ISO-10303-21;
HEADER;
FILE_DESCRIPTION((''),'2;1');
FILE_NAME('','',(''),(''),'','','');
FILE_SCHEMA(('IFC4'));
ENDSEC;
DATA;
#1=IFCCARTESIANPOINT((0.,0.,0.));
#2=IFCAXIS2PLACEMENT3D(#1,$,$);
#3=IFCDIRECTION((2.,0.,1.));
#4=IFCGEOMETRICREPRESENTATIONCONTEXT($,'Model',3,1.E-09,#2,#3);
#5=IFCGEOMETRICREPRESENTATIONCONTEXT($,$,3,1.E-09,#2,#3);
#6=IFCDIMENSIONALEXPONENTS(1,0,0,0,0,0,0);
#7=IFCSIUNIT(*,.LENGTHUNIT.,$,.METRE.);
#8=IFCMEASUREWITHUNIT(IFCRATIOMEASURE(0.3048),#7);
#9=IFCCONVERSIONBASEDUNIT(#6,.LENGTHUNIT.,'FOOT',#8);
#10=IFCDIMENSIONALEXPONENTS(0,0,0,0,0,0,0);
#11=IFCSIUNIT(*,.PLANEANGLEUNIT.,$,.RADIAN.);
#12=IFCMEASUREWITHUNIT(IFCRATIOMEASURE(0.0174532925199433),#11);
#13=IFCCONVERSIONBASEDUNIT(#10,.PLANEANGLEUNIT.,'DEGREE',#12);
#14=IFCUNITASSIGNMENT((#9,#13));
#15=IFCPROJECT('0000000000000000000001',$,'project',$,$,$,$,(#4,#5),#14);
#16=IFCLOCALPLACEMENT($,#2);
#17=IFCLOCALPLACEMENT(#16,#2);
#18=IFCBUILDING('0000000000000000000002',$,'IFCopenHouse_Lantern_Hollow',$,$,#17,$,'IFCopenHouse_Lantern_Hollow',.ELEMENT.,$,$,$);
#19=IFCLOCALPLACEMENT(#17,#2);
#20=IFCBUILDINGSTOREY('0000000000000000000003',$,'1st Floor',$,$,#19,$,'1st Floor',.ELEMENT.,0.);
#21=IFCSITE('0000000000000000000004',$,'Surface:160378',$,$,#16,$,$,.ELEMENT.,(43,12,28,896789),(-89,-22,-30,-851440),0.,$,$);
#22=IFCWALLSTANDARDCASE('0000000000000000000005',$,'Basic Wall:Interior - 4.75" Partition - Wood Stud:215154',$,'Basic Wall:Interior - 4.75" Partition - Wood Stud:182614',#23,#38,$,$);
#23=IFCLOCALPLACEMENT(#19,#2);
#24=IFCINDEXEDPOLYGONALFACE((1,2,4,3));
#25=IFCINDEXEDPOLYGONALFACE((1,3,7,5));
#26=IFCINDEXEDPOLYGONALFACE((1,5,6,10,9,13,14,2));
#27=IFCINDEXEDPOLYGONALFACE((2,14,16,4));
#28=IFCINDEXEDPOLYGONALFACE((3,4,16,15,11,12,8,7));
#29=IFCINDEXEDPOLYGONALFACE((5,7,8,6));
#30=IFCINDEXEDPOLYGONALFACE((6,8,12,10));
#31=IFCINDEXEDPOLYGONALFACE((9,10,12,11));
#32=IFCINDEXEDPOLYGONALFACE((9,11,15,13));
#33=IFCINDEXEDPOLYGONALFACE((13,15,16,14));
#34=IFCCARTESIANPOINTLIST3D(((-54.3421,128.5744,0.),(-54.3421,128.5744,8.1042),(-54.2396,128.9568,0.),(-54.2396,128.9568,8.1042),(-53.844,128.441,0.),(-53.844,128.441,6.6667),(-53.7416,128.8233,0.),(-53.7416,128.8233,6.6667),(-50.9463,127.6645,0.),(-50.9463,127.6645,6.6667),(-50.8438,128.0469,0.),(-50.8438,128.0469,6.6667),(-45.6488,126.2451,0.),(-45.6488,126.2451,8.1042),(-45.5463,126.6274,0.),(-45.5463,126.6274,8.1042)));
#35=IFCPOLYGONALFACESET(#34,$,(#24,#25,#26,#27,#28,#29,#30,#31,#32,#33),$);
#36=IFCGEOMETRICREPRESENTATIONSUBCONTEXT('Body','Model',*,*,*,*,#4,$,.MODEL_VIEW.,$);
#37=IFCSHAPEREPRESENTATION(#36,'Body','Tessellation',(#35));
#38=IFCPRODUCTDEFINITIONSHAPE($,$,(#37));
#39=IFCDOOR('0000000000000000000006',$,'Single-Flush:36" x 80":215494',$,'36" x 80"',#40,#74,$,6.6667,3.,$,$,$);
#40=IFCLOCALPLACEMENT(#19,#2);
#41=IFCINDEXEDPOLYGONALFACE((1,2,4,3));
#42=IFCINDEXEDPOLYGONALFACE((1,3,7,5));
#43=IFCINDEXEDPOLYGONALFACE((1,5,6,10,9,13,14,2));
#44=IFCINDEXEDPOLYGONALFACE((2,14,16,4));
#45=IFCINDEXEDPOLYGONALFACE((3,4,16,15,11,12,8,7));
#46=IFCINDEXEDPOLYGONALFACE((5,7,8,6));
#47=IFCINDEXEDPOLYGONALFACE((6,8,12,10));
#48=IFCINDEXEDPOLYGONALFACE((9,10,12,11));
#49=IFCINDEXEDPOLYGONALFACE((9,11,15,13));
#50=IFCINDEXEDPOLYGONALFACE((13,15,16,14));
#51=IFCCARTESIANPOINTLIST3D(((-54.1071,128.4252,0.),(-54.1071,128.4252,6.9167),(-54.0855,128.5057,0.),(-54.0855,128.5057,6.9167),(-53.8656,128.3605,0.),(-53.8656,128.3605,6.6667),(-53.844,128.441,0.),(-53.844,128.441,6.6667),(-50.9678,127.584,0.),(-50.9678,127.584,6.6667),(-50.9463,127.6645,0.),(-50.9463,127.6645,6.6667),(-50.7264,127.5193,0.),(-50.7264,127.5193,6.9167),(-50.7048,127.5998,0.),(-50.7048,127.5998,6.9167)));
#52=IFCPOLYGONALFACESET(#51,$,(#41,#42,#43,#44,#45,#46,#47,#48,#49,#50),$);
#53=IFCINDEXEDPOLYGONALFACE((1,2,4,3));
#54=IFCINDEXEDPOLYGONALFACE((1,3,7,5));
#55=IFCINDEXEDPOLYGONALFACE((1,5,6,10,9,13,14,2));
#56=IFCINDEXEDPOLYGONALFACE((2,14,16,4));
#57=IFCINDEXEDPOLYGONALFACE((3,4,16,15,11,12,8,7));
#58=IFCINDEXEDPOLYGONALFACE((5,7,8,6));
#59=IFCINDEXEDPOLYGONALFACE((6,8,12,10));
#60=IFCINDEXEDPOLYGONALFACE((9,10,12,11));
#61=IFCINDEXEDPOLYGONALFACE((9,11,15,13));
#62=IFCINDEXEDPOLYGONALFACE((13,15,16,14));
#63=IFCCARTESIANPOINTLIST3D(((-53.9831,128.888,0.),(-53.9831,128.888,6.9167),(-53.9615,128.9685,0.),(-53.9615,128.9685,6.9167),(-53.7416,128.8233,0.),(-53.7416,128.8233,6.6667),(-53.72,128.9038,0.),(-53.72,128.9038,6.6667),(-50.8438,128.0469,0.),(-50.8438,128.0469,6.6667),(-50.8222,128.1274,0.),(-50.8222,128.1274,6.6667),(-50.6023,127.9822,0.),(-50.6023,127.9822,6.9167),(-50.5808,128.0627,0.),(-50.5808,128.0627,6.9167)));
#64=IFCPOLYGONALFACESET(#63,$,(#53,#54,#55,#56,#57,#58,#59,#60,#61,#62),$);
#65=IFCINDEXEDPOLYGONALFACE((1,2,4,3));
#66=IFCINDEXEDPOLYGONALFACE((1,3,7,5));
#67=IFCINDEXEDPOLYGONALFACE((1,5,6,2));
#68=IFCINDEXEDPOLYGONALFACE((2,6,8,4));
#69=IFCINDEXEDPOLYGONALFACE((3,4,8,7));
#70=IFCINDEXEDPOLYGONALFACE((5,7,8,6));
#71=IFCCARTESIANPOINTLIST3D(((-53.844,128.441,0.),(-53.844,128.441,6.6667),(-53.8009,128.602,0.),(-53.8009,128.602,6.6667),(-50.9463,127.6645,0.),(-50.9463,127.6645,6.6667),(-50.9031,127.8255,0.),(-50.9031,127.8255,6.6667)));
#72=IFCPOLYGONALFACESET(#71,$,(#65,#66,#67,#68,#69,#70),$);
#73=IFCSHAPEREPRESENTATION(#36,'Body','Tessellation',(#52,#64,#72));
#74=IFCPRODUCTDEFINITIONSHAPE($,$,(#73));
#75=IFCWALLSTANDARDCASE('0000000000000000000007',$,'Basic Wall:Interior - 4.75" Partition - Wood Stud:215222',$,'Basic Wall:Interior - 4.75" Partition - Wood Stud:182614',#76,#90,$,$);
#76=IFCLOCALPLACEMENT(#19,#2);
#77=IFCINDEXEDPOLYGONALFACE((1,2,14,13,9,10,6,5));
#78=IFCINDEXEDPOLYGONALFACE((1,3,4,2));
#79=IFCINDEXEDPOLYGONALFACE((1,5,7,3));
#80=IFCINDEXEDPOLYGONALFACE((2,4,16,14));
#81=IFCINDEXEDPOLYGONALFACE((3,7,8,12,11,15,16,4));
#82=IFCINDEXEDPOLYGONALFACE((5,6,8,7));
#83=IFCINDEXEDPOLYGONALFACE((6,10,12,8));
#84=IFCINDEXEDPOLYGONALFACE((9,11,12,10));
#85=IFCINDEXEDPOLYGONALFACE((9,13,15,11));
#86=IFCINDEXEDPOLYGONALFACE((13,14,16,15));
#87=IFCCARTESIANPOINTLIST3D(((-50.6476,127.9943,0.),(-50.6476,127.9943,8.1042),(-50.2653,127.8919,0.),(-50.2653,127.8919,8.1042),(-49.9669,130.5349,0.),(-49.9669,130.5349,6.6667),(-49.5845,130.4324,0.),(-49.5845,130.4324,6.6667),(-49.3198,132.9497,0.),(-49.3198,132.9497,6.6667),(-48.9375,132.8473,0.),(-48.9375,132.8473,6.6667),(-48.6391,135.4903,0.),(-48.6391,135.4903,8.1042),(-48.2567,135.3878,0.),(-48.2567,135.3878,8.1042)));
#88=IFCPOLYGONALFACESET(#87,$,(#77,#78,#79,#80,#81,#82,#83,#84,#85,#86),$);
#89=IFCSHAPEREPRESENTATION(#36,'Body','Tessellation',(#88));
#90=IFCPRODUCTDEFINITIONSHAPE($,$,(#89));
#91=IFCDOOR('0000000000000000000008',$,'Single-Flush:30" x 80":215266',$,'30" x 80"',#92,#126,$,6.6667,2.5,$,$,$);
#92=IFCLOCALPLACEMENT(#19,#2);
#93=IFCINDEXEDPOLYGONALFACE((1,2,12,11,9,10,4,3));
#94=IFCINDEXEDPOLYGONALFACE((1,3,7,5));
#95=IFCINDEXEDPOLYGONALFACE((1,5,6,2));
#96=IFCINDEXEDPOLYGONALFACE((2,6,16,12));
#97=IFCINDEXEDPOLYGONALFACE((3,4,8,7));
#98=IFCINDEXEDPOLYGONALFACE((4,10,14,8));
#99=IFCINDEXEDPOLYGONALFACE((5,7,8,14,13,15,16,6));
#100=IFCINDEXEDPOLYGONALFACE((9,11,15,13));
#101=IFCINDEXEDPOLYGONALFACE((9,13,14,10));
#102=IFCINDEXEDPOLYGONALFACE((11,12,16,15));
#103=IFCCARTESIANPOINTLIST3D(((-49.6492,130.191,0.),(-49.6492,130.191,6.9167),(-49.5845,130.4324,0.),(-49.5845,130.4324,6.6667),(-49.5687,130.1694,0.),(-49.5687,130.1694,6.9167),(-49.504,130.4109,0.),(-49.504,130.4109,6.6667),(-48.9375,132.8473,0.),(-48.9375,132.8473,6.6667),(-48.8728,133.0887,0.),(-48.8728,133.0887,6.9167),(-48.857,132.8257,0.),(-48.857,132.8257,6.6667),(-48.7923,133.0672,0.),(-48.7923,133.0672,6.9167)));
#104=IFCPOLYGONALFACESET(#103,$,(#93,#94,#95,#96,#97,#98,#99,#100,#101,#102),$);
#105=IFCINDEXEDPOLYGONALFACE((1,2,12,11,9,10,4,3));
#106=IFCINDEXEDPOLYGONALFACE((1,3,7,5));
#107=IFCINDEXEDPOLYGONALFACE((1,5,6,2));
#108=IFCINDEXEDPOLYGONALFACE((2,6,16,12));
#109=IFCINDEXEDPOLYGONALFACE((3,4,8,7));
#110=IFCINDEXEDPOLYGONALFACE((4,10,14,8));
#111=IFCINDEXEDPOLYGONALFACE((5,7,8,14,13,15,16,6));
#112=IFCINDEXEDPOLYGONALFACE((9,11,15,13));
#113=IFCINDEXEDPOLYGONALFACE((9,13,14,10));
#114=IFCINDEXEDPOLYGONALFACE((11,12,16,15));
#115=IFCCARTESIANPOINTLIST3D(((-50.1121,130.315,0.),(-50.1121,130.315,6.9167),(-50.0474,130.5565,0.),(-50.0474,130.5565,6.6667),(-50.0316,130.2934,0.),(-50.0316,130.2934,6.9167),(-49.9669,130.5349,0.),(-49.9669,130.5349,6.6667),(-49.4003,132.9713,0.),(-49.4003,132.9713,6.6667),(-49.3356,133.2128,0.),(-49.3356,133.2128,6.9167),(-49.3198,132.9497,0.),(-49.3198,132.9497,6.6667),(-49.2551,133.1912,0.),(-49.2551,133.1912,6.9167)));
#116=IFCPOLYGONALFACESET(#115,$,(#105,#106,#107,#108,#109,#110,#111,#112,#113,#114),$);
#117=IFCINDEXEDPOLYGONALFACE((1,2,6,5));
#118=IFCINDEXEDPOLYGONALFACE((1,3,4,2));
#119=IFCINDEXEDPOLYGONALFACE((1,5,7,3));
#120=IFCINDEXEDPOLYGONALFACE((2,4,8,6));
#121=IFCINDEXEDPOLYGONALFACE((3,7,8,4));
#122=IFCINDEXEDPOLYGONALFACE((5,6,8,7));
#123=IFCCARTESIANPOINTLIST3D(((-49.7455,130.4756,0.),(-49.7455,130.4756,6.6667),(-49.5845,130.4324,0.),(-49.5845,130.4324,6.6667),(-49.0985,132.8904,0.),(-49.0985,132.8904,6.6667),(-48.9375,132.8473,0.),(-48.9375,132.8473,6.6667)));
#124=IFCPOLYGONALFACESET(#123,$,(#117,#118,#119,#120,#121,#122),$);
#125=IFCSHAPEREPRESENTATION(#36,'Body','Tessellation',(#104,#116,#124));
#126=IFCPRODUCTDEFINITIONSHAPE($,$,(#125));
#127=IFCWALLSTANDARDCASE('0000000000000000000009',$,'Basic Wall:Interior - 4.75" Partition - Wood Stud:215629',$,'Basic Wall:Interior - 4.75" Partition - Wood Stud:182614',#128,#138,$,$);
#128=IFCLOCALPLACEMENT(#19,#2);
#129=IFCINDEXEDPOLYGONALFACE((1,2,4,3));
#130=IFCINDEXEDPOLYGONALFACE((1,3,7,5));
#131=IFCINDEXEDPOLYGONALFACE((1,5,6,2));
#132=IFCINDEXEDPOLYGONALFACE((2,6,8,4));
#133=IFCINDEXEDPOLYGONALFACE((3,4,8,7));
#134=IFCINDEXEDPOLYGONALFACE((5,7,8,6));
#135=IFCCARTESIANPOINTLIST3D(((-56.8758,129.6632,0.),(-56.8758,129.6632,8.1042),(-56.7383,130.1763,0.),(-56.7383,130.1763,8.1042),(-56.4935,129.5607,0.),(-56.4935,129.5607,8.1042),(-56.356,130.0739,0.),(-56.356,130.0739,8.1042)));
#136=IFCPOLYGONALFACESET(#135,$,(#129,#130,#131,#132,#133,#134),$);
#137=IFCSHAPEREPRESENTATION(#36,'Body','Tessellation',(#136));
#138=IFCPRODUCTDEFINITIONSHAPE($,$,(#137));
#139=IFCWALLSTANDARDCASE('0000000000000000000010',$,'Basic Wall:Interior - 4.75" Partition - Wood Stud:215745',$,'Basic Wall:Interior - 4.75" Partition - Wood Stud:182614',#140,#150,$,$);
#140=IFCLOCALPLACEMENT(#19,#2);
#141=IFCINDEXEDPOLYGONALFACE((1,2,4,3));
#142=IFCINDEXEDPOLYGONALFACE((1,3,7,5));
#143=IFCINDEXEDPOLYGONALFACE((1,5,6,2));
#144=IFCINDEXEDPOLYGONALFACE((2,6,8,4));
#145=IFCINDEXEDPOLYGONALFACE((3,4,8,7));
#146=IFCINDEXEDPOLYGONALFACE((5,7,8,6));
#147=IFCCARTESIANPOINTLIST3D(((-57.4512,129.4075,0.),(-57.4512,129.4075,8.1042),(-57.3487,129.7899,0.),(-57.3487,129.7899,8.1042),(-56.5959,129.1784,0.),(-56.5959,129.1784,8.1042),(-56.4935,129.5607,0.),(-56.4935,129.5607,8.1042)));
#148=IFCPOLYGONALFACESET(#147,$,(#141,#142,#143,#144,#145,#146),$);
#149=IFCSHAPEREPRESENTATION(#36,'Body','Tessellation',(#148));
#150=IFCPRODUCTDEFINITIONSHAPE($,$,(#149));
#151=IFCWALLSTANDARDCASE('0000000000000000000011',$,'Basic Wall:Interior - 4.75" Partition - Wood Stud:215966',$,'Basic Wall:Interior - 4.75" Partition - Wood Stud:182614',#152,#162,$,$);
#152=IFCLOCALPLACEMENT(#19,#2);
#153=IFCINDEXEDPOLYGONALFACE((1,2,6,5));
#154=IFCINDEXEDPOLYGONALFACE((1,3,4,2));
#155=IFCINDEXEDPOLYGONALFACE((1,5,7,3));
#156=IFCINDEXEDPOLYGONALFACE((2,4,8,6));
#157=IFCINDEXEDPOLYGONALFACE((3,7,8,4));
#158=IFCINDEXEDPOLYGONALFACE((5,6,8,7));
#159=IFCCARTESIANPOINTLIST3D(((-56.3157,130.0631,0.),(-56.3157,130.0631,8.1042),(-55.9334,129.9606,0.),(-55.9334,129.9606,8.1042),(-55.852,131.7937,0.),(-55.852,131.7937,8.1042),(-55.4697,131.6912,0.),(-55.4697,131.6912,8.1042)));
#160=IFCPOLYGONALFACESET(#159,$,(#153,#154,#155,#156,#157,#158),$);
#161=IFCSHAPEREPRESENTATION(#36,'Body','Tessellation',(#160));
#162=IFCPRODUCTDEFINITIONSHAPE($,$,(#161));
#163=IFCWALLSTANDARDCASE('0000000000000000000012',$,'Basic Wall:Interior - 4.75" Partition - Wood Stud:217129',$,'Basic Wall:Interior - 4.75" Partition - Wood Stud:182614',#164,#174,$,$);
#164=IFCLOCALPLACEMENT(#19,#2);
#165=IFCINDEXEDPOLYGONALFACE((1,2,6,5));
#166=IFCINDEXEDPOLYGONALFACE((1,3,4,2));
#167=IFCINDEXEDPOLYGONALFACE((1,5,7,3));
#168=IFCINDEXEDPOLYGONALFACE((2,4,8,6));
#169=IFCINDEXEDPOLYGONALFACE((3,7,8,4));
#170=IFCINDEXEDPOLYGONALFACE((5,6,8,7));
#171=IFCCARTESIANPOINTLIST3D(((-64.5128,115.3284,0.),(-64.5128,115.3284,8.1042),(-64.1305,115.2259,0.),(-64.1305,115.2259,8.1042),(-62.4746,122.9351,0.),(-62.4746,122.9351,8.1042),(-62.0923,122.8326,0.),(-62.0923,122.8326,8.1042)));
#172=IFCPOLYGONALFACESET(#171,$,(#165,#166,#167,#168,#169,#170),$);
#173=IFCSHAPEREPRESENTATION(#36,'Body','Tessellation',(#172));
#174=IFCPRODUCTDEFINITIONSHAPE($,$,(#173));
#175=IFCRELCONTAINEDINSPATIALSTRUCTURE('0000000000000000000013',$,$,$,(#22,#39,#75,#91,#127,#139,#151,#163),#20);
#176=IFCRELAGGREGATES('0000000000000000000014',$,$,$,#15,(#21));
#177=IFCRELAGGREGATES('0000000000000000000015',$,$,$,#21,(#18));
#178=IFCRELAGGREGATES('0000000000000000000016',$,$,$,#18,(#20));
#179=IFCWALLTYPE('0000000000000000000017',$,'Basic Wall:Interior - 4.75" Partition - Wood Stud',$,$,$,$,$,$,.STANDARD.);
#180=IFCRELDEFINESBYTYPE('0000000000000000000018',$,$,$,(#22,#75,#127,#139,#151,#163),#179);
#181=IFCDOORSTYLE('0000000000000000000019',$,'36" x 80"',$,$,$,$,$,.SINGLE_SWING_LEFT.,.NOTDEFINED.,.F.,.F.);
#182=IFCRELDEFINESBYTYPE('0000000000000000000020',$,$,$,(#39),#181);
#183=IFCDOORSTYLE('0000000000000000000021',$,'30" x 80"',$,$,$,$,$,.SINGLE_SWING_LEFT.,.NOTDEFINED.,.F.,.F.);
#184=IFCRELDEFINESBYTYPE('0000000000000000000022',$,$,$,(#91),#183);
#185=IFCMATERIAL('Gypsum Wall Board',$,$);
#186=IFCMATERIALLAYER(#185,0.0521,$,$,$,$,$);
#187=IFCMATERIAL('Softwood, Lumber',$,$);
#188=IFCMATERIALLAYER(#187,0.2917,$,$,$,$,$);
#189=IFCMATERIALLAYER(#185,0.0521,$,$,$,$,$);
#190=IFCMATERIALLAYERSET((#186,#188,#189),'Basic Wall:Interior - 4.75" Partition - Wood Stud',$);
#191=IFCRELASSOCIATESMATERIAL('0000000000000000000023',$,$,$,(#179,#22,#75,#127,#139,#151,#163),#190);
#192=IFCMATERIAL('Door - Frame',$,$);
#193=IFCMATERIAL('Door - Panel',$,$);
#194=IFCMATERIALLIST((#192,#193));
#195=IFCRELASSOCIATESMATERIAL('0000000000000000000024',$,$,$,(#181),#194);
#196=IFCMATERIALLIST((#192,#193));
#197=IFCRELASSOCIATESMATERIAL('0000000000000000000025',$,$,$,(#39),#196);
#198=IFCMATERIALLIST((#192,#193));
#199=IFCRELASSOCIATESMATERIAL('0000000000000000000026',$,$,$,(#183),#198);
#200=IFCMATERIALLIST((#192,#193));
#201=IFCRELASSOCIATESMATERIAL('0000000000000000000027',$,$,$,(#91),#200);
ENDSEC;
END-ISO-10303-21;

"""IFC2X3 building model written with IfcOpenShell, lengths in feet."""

from ifc_helpers import new_model, entity, si_unit, converted_unit, direction, frame, frame_2d, origin, origin_2d_with_axis, place, context, subcontext, project, spatial, polyline, rectangle, outline, extrude, source, transform, mapped, material, material_list, layer, layer_set, layer_usage, type_object, type_shapes, element, fill, save


model = new_model("IFC2X3")

# Units and contexts
model_context = context("Model", 3, precision=1e-09, world=origin(), true_north=direction((2.0, 0.0, 1.0)))
context_of_model = context(None, 3, precision=1e-09, world=origin(), true_north=direction((2.0, 0.0, 1.0)))
body_context = subcontext(model_context, "Body", "Model", "MODEL_VIEW")
ifc_project = project(units=[converted_unit("LENGTHUNIT", "FOOT", entity("IfcRatioMeasure", 0.3048), si_unit("LENGTHUNIT", "METRE"), dimensions=[1, 0, 0, 0, 0, 0, 0]), converted_unit("PLANEANGLEUNIT", "DEGREE", entity("IfcRatioMeasure", 0.0174532925199433), si_unit("PLANEANGLEUNIT", "RADIAN"), dimensions=[0, 0, 0, 0, 0, 0, 0])], contexts=[model_context, context_of_model])

# Site, building, storey
site_placement = place(None, origin())
site = spatial("IfcSite", under=ifc_project, at=site_placement, Name="Surface:160378", CompositionType="ELEMENT", RefLatitude=(43, 12, 28, 896789), RefLongitude=(-89, -22, -30, -851440), RefElevation=0.0)
building_placement = place(site_placement, origin())
building = spatial("IfcBuilding", under=site, at=building_placement, Name="IFCopenHouse_Lantern_Hollow", LongName="IFCopenHouse_Lantern_Hollow", CompositionType="ELEMENT")
storey_placement = place(building_placement, origin())
storey = spatial("IfcBuildingStorey", under=building, at=storey_placement, Name="1st Floor", LongName="1st Floor", CompositionType="ELEMENT", Elevation=0.0)

# Shared definitions
ifc_material_1 = material(Name="Softwood, Lumber")

# Shared definitions
ifc_material_2 = material(Name="Gypsum Wall Board")

# Shared definitions
ifc_layer_1 = layer(ifc_material_2, 0.0521)
ifc_layer_2 = layer(ifc_material_1, 0.2917)
ifc_layer_3 = layer(ifc_material_2, 0.0521)
ifc_layer_set_1 = layer_set([ifc_layer_1, ifc_layer_2, ifc_layer_3], Name="Basic Wall:Interior - 4.75\" Partition - Wood Stud")
wall_type_1 = type_object("IfcWallType", Name="Basic Wall:Interior - 4.75\" Partition - Wood Stud", PredefinedType="STANDARD", material=ifc_layer_set_1)

# Shared definitions
ifc_material_3 = material(Name="Door - Panel")
ifc_material_4 = material(Name="Door - Frame")

# Walls, openings, doors
ifc_layer_usage_1 = layer_usage(ifc_layer_set_1, "AXIS2", "NEGATIVE", 0.1979)
wall_1_placement = place(storey_placement, frame((-45.5975, 126.4362, 0.0), z_axis=(0.0, 0.0, 1.0), x_axis=(-0.965926, 0.258819, 0.0)))
wall_1 = element("IfcWallStandardCase", 1, at=wall_1_placement, inside=storey, type_object=wall_type_1, material=ifc_layer_usage_1, Name="Basic Wall:Interior - 4.75\" Partition - Wood Stud:215154", ObjectType="Basic Wall:Interior - 4.75\" Partition - Wood Stud:182614", context=body_context, shape_type="SweptSolid", body=[
    extrude(rectangle(XDim=9.0, YDim=0.3958, at=frame_2d((4.5, 0.0), x_axis=(-1.0, 0.0))), origin(), (0.0, 0.0, 1.0), 8.1042),
])
opening_1_placement = place(wall_1_placement, frame((5.4844, -0.1979, 0.0)))
opening_1 = element("IfcOpeningElement", 2, at=opening_1_placement, cuts=wall_1, ObjectType="Opening", context=body_context, shape_type="SweptSolid", body=[
    extrude(rectangle(XDim=3.0, YDim=6.6667, at=frame_2d((3.3333, 1.5), x_axis=(0.0, -1.0))), frame((0.0, 0.0, 0.0), z_axis=(0.0, 1.0, 0.0), x_axis=(0.0, 0.0, 1.0)), (0.0, 0.0, 1.0), 0.3958),
])
ifc_material_list_1 = material_list([ifc_material_4, ifc_material_3])
ifc_material_list_2 = material_list([ifc_material_4, ifc_material_3])
door_style_1 = type_object("IfcDoorStyle", Name="36\" x 80\"", ConstructionType="NOTDEFINED", OperationType="SINGLE_SWING_LEFT", ParameterTakesPrecedence=False, Sizeable=False, material=ifc_material_list_2)
shared_shape_1 = source(origin(), body_context, "Body", "SweptSolid", [
    extrude(outline(polyline([(-1.75, -3.5208), (1.75, -3.5208), (1.75, 3.3958), (1.5, 3.3958), (1.5, -3.2708), (-1.5, -3.2708), (-1.5, 3.3958), (-1.75, 3.3958), (-1.75, -3.5208)])), frame((1.5, 0.4792, 3.3958), z_axis=(0.0, -1.0, 0.0), x_axis=(-1.0, 0.0, 0.0)), (0.0, 0.0, 1.0), 0.0833),
    extrude(outline(polyline([(-3.5208, -1.75), (3.3958, -1.75), (3.3958, -1.5), (-3.2708, -1.5), (-3.2708, 1.5), (3.3958, 1.5), (3.3958, 1.75), (-3.5208, 1.75), (-3.5208, -1.75)])), frame((1.5, 0.0, 3.3958), z_axis=(0.0, -1.0, 0.0), x_axis=(0.0, 0.0, -1.0)), (0.0, 0.0, 1.0), 0.0833),
    extrude(rectangle(XDim=3.0, YDim=0.1667, at=origin_2d_with_axis()), frame((1.5, 0.3125, 0.0)), (0.0, 0.0, 1.0), 6.6667),
])
type_shapes(door_style_1, [shared_shape_1])
door_1_placement = place(storey_placement, frame((-50.8438, 128.0469, 0.0), z_axis=(0.0, 0.0, 1.0), x_axis=(-0.965926, 0.258819, 0.0)))
door_1 = element("IfcDoor", 3, at=door_1_placement, inside=storey, type_object=door_style_1, material=ifc_material_list_1, Name="Single-Flush:36\" x 80\":215494", ObjectType="36\" x 80\"", OverallHeight=6.6667, OverallWidth=3.0, context=body_context, shape_type="MappedRepresentation", body=[
    mapped(shared_shape_1, transform((0.0, 0.0, 0.0), scale=1.0)),
])
fill(opening_1, door_1)
ifc_layer_usage_2 = layer_usage(ifc_layer_set_1, "AXIS2", "NEGATIVE", 0.1979)
wall_2_placement = place(storey_placement, frame((-50.4564, 127.9431, 0.0), z_axis=(0.0, 0.0, 1.0), x_axis=(0.258819, 0.965926, 0.0)))
wall_2 = element("IfcWallStandardCase", 4, at=wall_2_placement, inside=storey, type_object=wall_type_1, material=ifc_layer_usage_2, Name="Basic Wall:Interior - 4.75\" Partition - Wood Stud:215222", ObjectType="Basic Wall:Interior - 4.75\" Partition - Wood Stud:182614", context=body_context, shape_type="SweptSolid", body=[
    extrude(rectangle(XDim=7.7604, YDim=0.3958, at=frame_2d((3.8802, 0.0), x_axis=(-1.0, 0.0))), origin(), (0.0, 0.0, 1.0), 8.1042),
])
opening_2_placement = place(wall_2_placement, frame((5.1302, 0.1979, 0.0)))
opening_2 = element("IfcOpeningElement", 5, at=opening_2_placement, cuts=wall_2, ObjectType="Opening", context=body_context, shape_type="SweptSolid", body=[
    extrude(rectangle(XDim=2.5, YDim=6.6667, at=frame_2d((3.3333, 1.25), x_axis=(0.0, -1.0))), frame((0.0, 0.0, 0.0), z_axis=(0.0, -1.0, 0.0), x_axis=(0.0, 0.0, 1.0)), (0.0, 0.0, 1.0), 0.3958),
])
ifc_material_list_3 = material_list([ifc_material_4, ifc_material_3])
ifc_material_list_4 = material_list([ifc_material_4, ifc_material_3])
door_style_2 = type_object("IfcDoorStyle", Name="30\" x 80\"", ConstructionType="NOTDEFINED", OperationType="SINGLE_SWING_LEFT", ParameterTakesPrecedence=False, Sizeable=False, material=ifc_material_list_4)
shared_shape_2 = source(origin(), body_context, "Body", "SweptSolid", [
    extrude(outline(polyline([(-1.5, -3.5208), (1.5, -3.5208), (1.5, 3.3958), (1.25, 3.3958), (1.25, -3.2708), (-1.25, -3.2708), (-1.25, 3.3958), (-1.5, 3.3958), (-1.5, -3.5208)])), frame((1.25, 0.4792, 3.3958), z_axis=(0.0, -1.0, 0.0), x_axis=(-1.0, 0.0, 0.0)), (0.0, 0.0, 1.0), 0.0833),
    extrude(outline(polyline([(-3.5208, -1.5), (3.3958, -1.5), (3.3958, -1.25), (-3.2708, -1.25), (-3.2708, 1.25), (3.3958, 1.25), (3.3958, 1.5), (-3.5208, 1.5), (-3.5208, -1.5)])), frame((1.25, 0.0, 3.3958), z_axis=(0.0, -1.0, 0.0), x_axis=(0.0, 0.0, -1.0)), (0.0, 0.0, 1.0), 0.0833),
    extrude(rectangle(XDim=2.5, YDim=0.1667, at=origin_2d_with_axis()), frame((1.25, 0.3125, 0.0)), (0.0, 0.0, 1.0), 6.6667),
])
type_shapes(door_style_2, [shared_shape_2])
door_2_placement = place(storey_placement, frame((-49.3198, 132.9497, 0.0), z_axis=(0.0, 0.0, 1.0), x_axis=(-0.258819, -0.965926, 0.0)))
door_2 = element("IfcDoor", 6, at=door_2_placement, inside=storey, type_object=door_style_2, material=ifc_material_list_3, Name="Single-Flush:30\" x 80\":215266", ObjectType="30\" x 80\"", OverallHeight=6.6667, OverallWidth=2.5, context=body_context, shape_type="MappedRepresentation", body=[
    mapped(shared_shape_2, transform((0.0, 0.0, 0.0), scale=1.0)),
])
fill(opening_2, door_2)

# Walls
ifc_layer_usage_3 = layer_usage(ifc_layer_set_1, "AXIS2", "NEGATIVE", 0.1979)
wall_3_placement = place(storey_placement, frame((-56.6846, 129.6119, 0.0), z_axis=(0.0, 0.0, 1.0), x_axis=(0.258819, 0.965926, 0.0)))
element("IfcWallStandardCase", 7, at=wall_3_placement, inside=storey, type_object=wall_type_1, material=ifc_layer_usage_3, Name="Basic Wall:Interior - 4.75\" Partition - Wood Stud:215629", ObjectType="Basic Wall:Interior - 4.75\" Partition - Wood Stud:182614", context=body_context, shape_type="SweptSolid", body=[
    extrude(rectangle(XDim=0.5312, YDim=0.3958, at=frame_2d((0.2656, 0.0), x_axis=(-1.0, 0.0))), origin(), (0.0, 0.0, 1.0), 8.1042),
])
ifc_layer_usage_4 = layer_usage(ifc_layer_set_1, "AXIS2", "NEGATIVE", 0.1979)
wall_4_placement = place(storey_placement, frame((-56.5447, 129.3695, 0.0), z_axis=(0.0, 0.0, 1.0), x_axis=(-0.965926, 0.258819, 0.0)))
element("IfcWallStandardCase", 8, at=wall_4_placement, inside=storey, type_object=wall_type_1, material=ifc_layer_usage_4, Name="Basic Wall:Interior - 4.75\" Partition - Wood Stud:215745", ObjectType="Basic Wall:Interior - 4.75\" Partition - Wood Stud:182614", context=body_context, shape_type="SweptSolid", body=[
    extrude(rectangle(XDim=0.8854, YDim=0.3958, at=frame_2d((0.4427, 0.0), x_axis=(-1.0, 0.0))), origin(), (0.0, 0.0, 1.0), 8.1042),
])
ifc_layer_usage_5 = layer_usage(ifc_layer_set_1, "AXIS2", "NEGATIVE", 0.1979)
wall_5_placement = place(storey_placement, frame((-56.1246, 130.0118, 0.0), z_axis=(0.0, 0.0, 1.0), x_axis=(0.258819, 0.965926, 0.0)))
element("IfcWallStandardCase", 9, at=wall_5_placement, inside=storey, type_object=wall_type_1, material=ifc_layer_usage_5, Name="Basic Wall:Interior - 4.75\" Partition - Wood Stud:215966", ObjectType="Basic Wall:Interior - 4.75\" Partition - Wood Stud:182614", context=body_context, shape_type="SweptSolid", body=[
    extrude(rectangle(XDim=1.7917, YDim=0.3958, at=frame_2d((0.8958, 0.0), x_axis=(-1.0, 0.0))), origin(), (0.0, 0.0, 1.0), 8.1042),
])
ifc_layer_usage_6 = layer_usage(ifc_layer_set_1, "AXIS2", "NEGATIVE", 0.1979)
wall_6_placement = place(storey_placement, frame((-64.3216, 115.2772, 0.0), z_axis=(0.0, 0.0, 1.0), x_axis=(0.258819, 0.965926, 0.0)))
element("IfcWallStandardCase", 10, at=wall_6_placement, inside=storey, type_object=wall_type_1, material=ifc_layer_usage_6, Name="Basic Wall:Interior - 4.75\" Partition - Wood Stud:217129", ObjectType="Basic Wall:Interior - 4.75\" Partition - Wood Stud:182614", context=body_context, shape_type="SweptSolid", body=[
    extrude(rectangle(XDim=7.875, YDim=0.3958, at=frame_2d((3.9375, 0.0), x_axis=(-1.0, 0.0))), origin(), (0.0, 0.0, 1.0), 8.1042),
])

save(model, "model.ifc")
